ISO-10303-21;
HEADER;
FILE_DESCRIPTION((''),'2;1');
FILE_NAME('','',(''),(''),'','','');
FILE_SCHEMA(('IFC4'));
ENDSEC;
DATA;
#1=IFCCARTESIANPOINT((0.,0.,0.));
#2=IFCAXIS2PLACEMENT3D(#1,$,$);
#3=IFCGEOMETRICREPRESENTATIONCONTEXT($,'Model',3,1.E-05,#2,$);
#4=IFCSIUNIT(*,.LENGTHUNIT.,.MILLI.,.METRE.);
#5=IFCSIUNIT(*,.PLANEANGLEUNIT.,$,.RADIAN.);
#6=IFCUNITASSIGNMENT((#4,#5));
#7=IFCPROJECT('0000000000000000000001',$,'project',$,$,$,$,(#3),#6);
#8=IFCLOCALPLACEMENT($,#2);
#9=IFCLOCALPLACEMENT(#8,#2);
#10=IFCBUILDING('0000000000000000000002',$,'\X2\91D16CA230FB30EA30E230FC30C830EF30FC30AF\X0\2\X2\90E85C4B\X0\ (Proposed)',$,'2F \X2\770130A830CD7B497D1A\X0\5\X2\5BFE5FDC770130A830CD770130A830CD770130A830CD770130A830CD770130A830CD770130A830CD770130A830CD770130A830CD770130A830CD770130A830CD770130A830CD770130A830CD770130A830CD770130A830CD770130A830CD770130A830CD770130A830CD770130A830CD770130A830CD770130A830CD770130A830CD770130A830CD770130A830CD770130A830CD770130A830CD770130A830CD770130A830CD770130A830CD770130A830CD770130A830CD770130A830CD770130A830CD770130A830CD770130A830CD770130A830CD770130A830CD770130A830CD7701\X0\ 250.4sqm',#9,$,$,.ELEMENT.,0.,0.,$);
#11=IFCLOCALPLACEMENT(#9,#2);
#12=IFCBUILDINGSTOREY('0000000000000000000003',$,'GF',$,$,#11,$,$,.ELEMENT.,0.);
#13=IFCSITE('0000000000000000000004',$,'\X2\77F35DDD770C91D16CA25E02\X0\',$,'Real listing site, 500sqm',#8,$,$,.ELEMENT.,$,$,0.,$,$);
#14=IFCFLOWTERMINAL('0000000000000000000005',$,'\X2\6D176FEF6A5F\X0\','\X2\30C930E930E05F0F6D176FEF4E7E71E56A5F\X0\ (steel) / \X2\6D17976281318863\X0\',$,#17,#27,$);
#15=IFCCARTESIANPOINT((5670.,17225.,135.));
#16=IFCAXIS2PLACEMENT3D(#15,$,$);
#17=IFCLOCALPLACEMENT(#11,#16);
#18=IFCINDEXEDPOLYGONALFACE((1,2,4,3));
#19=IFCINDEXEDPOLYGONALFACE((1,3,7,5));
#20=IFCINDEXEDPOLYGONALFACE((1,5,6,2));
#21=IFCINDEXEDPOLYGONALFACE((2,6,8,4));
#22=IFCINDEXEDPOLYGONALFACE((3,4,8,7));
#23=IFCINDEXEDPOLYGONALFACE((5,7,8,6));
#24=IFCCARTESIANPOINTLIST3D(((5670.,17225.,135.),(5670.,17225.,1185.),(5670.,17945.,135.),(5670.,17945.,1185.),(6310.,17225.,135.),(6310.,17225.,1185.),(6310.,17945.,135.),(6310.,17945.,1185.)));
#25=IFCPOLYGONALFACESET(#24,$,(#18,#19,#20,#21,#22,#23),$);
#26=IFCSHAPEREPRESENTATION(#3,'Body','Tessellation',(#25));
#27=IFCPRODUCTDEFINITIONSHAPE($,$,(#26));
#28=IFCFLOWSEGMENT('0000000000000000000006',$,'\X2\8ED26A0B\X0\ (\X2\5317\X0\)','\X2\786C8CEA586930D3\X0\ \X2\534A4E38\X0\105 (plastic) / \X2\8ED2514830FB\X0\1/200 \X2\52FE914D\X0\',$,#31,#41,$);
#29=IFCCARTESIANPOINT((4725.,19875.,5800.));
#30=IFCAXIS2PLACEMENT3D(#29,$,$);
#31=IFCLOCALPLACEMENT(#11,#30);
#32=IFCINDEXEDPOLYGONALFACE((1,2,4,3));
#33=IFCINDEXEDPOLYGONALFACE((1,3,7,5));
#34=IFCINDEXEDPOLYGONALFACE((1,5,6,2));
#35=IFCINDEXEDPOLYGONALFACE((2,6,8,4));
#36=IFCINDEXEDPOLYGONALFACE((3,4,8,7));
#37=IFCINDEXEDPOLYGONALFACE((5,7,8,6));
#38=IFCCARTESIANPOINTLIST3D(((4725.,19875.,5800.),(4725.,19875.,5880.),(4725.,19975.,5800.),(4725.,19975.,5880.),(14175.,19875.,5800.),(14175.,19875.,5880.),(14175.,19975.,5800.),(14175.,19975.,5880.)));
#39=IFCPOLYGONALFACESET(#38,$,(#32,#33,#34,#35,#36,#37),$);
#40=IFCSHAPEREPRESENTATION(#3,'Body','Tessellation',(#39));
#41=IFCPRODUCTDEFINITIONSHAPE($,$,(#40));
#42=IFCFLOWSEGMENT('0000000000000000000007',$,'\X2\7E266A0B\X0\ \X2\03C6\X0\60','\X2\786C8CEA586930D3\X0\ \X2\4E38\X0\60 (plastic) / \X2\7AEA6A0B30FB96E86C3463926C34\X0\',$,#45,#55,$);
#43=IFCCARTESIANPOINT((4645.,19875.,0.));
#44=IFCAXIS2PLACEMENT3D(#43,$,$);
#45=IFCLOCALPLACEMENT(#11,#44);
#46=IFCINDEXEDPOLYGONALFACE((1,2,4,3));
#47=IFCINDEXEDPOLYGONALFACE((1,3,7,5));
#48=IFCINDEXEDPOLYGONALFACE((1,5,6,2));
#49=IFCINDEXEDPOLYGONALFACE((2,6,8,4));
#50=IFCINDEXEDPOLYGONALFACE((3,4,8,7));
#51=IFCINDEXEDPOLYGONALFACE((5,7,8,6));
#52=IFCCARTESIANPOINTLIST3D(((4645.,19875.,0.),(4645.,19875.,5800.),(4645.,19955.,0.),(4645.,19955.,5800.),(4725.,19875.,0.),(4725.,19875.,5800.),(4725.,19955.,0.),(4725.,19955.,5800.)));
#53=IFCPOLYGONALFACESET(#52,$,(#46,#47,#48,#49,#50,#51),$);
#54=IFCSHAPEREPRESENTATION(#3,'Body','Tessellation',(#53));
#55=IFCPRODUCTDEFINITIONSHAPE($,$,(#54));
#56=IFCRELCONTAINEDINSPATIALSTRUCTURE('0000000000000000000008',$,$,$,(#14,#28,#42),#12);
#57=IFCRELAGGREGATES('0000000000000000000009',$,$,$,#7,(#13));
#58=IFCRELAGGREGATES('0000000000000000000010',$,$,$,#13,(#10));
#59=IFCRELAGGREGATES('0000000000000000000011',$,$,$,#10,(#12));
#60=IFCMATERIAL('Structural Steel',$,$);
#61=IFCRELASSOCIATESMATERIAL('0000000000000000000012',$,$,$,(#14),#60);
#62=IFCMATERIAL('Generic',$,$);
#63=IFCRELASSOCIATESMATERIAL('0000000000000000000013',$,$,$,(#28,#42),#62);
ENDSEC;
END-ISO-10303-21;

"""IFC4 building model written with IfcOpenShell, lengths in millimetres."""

from ifc_helpers import new_model, si_unit, frame, frame_2d, origin, place, context, project, spatial, rectangle, extrude, material, element, save


model = new_model("IFC4")

# Units and contexts
model_context = context("Model", 3, precision=1e-05, world=origin())
ifc_project = project(units=[si_unit("LENGTHUNIT", "METRE", prefix="MILLI"), si_unit("PLANEANGLEUNIT", "RADIAN")], contexts=[model_context])

# Site, building, storey
site_placement = place(None, origin())
site = spatial("IfcSite", under=ifc_project, at=site_placement, Name="石川県金沢市", ObjectType="Real listing site, 500sqm", CompositionType="ELEMENT", RefElevation=0.0)
building_placement = place(site_placement, origin())
building = spatial("IfcBuilding", under=site, at=building_placement, Name="金沢・リモートワーク2部屋 (Proposed)", ObjectType="2F 省エネ等級5対応省エネ省エネ省エネ省エネ省エネ省エネ省エネ省エネ省エネ省エネ省エネ省エネ省エネ省エネ省エネ省エネ省エネ省エネ省エネ省エネ省エネ省エネ省エネ省エネ省エネ省エネ省エネ省エネ省エネ省エネ省エネ省エネ省エネ省エネ省エネ省エネ省エネ省 250.4sqm", CompositionType="ELEMENT", ElevationOfRefHeight=0.0, ElevationOfTerrain=0.0)
storey_placement = place(building_placement, origin())
storey = spatial("IfcBuildingStorey", under=building, at=storey_placement, Name="GF", CompositionType="ELEMENT", Elevation=0.0)

# Flow terminal
ifc_material_1 = material(Name="Structural Steel")
flow_terminal_placement = place(storey_placement, frame((5670.0, 17225.0, 135.0)))
element("IfcFlowTerminal", 1, at=flow_terminal_placement, inside=storey, material=ifc_material_1, Name="洗濯機", Description="ドラム式洗濯乾燥機 (steel) / 洗面脱衣", context=model_context, shape_type="SweptSolid", body=[
    extrude(rectangle(XDim=640.0, YDim=720.0, at=frame_2d((320.0, 360.0))), frame((5670.0, 17225.0, 135.0)), (0.0, 0.0, 1.0), 1050.0),
])

# Flow segments
ifc_material_2 = material(Name="Generic")
flow_segment_1_placement = place(storey_placement, frame((4725.0, 19875.0, 5800.0)))
element("IfcFlowSegment", 2, at=flow_segment_1_placement, inside=storey, material=ifc_material_2, Name="軒樋 (北)", Description="硬質塩ビ 半丸105 (plastic) / 軒先・1/200 勾配", context=model_context, shape_type="SweptSolid", body=[
    extrude(rectangle(XDim=9450.0, YDim=100.0, at=frame_2d((4725.0, 50.0))), frame((4725.0, 19875.0, 5800.0)), (0.0, 0.0, 1.0), 80.0),
])
flow_segment_2_placement = place(storey_placement, frame((4645.0, 19875.0, 0.0)))
element("IfcFlowSegment", 3, at=flow_segment_2_placement, inside=storey, material=ifc_material_2, Name="縦樋 φ60", Description="硬質塩ビ 丸60 (plastic) / 竪樋・雨水排水", context=model_context, shape_type="SweptSolid", body=[
    extrude(rectangle(XDim=80.0, YDim=80.0, at=frame_2d((40.0, 40.0))), frame((4645.0, 19875.0, 0.0)), (0.0, 0.0, 1.0), 5800.0),
])

save(model, "model.ifc")
